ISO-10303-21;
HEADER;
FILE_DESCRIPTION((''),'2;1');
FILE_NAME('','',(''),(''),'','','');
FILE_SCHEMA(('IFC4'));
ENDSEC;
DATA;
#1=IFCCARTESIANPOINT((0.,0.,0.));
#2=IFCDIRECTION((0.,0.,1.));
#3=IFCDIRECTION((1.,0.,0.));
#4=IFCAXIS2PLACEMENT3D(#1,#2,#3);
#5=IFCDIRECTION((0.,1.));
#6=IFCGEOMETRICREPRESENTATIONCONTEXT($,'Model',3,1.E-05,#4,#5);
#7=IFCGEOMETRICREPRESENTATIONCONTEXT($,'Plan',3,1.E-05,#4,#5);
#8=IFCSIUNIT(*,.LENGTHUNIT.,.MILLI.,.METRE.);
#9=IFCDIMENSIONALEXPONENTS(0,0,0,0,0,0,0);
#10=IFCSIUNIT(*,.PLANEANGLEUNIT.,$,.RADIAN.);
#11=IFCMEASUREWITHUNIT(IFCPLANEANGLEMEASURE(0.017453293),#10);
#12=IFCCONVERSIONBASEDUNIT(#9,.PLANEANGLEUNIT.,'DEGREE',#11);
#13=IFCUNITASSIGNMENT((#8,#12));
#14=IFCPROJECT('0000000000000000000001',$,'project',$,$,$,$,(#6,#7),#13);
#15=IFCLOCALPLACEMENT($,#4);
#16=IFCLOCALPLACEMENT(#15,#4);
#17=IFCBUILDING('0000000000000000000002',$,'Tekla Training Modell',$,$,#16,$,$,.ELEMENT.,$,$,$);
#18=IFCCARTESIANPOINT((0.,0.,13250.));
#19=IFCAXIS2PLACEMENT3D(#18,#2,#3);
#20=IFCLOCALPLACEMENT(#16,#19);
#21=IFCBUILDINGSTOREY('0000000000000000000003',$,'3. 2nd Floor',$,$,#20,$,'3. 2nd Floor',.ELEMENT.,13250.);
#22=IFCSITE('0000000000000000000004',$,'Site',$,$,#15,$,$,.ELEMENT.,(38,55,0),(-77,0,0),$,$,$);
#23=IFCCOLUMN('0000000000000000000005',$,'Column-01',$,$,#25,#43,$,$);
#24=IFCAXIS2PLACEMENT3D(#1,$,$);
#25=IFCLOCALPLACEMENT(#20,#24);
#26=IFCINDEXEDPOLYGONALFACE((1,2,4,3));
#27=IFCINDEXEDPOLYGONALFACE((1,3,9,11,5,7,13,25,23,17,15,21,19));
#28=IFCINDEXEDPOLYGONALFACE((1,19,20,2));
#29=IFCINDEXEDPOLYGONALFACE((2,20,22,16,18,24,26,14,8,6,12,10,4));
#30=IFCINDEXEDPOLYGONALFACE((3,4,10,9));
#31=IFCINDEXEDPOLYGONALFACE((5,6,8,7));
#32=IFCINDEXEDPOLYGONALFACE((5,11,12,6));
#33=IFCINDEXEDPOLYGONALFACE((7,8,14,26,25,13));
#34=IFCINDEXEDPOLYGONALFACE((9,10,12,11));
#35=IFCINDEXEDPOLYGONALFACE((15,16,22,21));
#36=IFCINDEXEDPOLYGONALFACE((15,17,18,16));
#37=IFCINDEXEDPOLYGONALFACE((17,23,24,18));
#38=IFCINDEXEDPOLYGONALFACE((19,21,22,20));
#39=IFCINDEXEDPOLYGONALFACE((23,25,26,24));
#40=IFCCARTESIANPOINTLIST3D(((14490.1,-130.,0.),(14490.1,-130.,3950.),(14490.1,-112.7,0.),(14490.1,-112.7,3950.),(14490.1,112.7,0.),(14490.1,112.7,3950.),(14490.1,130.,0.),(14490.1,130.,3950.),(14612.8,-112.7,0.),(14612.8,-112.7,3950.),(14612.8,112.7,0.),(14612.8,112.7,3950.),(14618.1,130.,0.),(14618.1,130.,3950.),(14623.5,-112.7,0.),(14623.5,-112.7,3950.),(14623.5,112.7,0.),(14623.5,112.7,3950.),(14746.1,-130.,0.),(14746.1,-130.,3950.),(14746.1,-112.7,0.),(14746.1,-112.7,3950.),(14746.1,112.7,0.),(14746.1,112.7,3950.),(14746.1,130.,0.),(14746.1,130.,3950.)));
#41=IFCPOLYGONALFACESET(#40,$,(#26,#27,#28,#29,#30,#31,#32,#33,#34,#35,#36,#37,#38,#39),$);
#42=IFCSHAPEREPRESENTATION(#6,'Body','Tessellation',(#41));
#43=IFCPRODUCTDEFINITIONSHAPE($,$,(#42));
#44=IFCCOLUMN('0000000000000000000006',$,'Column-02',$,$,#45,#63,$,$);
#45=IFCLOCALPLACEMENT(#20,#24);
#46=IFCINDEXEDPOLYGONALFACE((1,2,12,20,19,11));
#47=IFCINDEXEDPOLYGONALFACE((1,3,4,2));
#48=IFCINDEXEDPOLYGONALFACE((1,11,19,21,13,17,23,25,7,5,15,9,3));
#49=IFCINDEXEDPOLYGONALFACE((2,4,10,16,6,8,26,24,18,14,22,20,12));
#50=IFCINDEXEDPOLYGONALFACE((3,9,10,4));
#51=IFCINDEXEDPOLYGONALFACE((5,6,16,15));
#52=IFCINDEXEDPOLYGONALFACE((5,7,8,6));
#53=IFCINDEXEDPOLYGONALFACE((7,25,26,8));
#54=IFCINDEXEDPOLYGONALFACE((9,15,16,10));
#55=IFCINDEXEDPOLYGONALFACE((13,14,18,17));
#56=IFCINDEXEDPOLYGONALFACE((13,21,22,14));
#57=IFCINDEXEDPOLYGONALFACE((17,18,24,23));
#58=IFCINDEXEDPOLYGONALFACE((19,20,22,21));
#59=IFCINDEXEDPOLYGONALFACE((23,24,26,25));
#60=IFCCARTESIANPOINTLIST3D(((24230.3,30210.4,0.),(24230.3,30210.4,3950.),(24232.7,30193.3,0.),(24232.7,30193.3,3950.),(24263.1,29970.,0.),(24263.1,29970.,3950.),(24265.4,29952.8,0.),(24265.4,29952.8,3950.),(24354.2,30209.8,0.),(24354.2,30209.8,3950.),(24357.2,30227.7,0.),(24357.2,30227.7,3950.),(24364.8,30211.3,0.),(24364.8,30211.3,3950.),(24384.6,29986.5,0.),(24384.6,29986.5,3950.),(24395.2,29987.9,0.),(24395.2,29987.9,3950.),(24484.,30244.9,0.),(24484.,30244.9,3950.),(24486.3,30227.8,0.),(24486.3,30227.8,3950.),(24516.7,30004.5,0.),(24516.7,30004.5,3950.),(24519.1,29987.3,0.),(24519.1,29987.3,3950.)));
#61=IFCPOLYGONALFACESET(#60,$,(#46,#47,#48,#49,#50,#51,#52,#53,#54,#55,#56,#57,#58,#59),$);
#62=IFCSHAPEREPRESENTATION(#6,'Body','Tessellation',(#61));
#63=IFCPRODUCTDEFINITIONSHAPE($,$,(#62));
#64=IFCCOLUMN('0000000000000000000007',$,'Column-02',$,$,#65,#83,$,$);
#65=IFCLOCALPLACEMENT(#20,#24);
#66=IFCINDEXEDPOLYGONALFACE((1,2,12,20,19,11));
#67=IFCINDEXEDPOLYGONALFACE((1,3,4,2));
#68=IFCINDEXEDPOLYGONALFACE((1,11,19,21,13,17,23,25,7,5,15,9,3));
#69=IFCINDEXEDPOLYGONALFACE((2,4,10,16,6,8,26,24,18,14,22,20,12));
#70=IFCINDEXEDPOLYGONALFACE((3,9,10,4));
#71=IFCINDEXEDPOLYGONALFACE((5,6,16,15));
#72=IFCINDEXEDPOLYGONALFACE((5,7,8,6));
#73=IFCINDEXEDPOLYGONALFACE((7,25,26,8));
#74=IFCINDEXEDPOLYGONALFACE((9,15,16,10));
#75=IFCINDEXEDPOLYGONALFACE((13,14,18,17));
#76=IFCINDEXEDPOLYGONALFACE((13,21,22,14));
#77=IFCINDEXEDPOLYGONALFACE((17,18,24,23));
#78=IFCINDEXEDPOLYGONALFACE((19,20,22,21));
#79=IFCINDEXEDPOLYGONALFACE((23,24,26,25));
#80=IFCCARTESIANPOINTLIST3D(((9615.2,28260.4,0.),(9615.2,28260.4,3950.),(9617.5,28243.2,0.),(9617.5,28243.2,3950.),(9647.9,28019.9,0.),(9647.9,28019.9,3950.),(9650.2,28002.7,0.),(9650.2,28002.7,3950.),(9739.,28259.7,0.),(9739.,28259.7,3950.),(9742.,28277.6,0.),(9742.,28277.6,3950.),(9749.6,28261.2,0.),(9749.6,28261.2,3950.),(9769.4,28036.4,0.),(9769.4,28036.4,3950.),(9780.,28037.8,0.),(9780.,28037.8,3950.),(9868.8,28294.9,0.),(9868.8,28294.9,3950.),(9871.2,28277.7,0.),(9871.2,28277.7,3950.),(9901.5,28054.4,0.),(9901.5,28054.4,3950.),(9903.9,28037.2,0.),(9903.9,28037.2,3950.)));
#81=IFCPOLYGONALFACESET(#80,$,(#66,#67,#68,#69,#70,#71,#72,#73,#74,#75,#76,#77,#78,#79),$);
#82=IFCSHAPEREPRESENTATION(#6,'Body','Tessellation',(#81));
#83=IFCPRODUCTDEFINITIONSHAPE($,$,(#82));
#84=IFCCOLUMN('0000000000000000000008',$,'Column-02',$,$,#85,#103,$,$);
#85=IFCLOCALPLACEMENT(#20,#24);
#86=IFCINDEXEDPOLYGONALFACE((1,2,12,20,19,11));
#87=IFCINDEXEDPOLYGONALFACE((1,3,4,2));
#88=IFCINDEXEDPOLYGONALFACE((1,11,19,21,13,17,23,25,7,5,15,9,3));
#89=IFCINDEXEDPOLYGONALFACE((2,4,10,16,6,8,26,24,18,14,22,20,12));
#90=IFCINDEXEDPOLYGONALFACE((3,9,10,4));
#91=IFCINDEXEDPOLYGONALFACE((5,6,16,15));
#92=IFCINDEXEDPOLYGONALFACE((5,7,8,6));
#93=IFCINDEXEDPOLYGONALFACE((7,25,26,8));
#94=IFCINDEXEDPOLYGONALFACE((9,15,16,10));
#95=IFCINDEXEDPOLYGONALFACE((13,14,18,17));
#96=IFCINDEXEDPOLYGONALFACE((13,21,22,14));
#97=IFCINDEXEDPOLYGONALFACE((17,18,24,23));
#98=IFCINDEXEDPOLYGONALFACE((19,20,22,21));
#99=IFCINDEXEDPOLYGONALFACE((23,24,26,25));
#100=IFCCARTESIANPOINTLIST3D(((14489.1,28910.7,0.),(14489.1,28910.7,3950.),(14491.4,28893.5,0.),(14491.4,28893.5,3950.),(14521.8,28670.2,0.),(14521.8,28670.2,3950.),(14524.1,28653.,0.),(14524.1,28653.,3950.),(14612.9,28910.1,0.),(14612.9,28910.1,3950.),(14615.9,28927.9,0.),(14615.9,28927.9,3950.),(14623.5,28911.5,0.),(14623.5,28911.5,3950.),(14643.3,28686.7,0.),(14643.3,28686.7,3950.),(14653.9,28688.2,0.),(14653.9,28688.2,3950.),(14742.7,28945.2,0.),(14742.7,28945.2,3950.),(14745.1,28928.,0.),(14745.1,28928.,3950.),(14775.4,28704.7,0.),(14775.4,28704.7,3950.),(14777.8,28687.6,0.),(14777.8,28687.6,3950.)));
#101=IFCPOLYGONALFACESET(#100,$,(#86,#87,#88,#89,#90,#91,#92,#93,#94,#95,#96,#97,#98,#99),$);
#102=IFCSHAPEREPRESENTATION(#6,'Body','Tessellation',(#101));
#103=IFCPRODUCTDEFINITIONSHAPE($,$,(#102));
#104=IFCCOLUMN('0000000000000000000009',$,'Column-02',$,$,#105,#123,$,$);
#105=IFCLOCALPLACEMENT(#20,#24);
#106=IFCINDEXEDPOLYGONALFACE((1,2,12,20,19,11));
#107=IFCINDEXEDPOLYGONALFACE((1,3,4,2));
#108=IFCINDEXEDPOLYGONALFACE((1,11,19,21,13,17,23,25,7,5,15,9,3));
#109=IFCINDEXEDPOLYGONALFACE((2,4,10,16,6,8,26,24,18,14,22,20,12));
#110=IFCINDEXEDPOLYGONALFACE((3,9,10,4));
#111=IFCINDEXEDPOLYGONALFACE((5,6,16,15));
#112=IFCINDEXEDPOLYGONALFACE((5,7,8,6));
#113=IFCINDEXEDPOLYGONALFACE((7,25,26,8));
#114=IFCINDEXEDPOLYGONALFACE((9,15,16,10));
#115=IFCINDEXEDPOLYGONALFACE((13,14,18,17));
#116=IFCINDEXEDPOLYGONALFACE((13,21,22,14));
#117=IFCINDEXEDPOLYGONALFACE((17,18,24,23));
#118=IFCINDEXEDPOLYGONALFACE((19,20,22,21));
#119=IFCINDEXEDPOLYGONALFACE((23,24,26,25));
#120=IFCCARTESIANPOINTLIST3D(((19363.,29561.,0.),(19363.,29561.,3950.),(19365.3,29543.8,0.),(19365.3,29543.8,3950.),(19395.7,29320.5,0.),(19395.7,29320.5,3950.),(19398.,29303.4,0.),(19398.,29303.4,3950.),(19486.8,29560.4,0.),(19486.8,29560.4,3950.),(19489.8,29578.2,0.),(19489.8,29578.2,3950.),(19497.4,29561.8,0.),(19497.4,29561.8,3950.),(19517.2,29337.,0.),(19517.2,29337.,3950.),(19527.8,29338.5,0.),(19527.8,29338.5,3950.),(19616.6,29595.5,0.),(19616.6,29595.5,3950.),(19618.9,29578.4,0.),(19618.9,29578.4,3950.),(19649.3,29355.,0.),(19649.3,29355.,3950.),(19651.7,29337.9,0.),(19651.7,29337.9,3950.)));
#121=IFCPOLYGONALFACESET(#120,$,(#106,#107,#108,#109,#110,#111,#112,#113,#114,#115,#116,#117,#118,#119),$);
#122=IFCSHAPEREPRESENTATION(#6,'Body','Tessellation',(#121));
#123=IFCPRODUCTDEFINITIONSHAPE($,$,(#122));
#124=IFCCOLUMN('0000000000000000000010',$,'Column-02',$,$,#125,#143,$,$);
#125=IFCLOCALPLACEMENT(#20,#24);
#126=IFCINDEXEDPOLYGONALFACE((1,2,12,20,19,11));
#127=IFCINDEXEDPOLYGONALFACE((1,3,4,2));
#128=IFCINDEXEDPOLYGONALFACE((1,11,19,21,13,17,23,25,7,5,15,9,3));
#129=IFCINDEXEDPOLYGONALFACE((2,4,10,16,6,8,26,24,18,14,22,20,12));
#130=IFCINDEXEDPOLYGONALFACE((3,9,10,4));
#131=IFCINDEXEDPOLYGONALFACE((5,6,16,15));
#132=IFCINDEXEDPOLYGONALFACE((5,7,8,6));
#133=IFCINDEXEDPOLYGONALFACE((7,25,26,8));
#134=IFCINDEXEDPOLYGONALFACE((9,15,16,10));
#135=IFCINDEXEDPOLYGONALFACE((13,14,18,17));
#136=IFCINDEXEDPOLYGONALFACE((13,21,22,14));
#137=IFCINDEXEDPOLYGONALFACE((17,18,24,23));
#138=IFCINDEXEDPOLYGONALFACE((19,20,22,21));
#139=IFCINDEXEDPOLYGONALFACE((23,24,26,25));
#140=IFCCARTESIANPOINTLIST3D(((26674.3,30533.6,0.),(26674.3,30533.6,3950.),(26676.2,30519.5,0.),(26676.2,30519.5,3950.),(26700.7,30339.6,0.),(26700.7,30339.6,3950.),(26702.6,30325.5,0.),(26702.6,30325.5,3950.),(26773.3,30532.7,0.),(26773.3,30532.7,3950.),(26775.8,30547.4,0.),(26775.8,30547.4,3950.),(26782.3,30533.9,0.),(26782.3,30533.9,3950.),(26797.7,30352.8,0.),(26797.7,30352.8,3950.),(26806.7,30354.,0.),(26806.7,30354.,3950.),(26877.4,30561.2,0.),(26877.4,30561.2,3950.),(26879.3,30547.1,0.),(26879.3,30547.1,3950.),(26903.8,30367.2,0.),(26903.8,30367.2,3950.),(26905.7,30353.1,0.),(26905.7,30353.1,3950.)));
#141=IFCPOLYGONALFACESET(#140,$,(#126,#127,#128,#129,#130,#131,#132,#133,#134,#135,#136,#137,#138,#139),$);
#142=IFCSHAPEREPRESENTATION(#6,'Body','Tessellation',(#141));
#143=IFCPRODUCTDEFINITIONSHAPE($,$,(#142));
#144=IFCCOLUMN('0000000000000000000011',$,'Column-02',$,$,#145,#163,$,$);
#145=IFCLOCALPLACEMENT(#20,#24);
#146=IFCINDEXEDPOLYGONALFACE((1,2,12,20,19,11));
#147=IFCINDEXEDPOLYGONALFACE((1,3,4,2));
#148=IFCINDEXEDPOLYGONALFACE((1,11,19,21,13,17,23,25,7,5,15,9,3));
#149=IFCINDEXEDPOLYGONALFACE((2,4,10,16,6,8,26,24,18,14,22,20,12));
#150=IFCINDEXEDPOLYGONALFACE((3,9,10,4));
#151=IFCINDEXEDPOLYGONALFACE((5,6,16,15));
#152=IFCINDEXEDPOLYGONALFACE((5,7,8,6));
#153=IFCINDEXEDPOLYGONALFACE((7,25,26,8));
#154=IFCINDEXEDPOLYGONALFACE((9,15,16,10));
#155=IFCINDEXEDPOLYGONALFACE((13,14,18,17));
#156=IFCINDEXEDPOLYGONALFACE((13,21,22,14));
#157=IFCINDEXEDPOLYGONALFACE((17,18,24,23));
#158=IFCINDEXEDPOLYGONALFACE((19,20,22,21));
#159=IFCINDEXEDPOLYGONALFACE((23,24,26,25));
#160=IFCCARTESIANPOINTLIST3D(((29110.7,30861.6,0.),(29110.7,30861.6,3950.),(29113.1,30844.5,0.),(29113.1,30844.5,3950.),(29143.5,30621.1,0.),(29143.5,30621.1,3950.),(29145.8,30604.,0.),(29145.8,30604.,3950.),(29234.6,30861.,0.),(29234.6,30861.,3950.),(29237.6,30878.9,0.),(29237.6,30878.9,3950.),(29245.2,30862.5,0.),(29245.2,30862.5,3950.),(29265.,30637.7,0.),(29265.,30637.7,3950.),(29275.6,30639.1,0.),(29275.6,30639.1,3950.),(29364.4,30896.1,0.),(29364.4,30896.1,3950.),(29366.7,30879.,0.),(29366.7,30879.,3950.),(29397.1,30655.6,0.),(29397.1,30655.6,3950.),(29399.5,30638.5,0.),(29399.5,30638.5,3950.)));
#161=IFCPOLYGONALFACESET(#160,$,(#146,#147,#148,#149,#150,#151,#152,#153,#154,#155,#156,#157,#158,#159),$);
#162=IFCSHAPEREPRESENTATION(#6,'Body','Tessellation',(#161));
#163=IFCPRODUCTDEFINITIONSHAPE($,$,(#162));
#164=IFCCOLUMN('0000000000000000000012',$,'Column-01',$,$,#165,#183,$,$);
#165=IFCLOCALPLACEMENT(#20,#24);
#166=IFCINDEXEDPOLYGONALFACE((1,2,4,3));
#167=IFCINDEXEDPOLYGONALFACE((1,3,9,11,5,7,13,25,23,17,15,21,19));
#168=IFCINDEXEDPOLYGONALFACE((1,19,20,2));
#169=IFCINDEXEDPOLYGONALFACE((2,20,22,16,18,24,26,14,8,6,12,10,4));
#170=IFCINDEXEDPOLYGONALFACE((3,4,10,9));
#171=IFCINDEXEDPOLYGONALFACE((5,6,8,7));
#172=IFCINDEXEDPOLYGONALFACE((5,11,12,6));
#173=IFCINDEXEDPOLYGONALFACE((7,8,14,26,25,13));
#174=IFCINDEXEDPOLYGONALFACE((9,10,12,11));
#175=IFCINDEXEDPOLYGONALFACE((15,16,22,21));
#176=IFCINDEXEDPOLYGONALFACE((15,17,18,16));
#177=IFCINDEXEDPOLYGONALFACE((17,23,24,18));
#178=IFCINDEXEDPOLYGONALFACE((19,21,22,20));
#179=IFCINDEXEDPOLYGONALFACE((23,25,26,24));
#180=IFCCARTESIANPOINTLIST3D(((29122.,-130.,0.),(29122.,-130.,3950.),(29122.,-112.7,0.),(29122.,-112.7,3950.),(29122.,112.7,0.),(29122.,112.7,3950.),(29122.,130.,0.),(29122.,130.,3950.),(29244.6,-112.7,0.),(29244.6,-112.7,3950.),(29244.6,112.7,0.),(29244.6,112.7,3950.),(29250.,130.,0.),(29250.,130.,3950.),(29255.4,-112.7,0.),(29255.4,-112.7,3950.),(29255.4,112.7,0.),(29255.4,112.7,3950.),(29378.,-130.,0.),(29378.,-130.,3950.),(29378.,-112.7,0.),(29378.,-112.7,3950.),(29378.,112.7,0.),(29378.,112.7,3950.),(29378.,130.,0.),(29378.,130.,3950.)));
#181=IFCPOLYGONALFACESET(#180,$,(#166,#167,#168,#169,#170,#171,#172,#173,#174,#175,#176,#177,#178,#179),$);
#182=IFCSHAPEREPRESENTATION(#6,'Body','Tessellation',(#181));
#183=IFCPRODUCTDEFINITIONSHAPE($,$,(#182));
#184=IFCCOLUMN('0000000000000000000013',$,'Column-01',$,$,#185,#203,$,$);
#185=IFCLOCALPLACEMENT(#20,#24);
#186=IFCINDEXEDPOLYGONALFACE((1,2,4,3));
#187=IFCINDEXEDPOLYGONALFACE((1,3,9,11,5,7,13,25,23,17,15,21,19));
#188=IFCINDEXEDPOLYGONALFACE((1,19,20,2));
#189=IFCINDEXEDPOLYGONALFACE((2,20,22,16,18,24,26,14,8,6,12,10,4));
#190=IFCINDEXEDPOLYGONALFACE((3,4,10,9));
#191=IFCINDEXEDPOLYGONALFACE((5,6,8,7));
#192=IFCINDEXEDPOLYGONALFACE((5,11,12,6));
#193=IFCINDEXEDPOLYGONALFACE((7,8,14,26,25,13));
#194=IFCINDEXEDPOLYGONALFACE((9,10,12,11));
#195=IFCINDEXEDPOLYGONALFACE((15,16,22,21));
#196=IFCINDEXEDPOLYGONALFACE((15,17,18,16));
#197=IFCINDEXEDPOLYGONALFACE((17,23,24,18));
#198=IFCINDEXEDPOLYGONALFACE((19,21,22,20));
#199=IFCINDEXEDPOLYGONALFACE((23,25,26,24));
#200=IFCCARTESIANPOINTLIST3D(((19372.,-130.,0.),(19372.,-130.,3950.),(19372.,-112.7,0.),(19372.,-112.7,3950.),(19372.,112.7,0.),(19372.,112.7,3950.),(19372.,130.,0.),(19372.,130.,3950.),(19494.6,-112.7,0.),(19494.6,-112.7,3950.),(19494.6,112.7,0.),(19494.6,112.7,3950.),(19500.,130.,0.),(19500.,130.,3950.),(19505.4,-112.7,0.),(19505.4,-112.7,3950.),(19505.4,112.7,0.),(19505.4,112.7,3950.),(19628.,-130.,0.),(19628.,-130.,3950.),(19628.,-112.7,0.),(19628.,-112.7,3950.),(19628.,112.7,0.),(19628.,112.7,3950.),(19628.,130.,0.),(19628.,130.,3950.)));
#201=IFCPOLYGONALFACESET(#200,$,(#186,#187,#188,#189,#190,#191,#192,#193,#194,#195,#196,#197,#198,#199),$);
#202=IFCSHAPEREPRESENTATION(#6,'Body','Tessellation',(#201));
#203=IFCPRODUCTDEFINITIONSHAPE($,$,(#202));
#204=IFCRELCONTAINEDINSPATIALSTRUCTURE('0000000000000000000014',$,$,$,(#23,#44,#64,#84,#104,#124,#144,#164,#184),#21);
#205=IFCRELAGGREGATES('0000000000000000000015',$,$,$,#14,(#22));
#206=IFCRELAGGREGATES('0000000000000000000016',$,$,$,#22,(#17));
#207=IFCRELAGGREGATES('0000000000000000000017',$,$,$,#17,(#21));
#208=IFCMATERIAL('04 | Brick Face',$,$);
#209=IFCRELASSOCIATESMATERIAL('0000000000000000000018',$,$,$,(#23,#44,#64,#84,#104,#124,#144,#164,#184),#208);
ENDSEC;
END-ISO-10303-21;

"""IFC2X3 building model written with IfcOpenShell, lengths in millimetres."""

from ifc_helpers import new_model, entity, si_unit, converted_unit, direction, frame, origin_with_axes, place, context, project, spatial, polyline, outline, extrude, material, element, save


model = new_model("IFC2X3")

# Units and contexts
model_context = context("Model", 3, precision=1e-05, world=origin_with_axes(), true_north=direction((0.0, 1.0)))
plan_context = context("Plan", 3, precision=1e-05, world=origin_with_axes(), true_north=direction((0.0, 1.0)))
ifc_project = project(units=[si_unit("LENGTHUNIT", "METRE", prefix="MILLI"), converted_unit("PLANEANGLEUNIT", "DEGREE", entity("IfcPlaneAngleMeasure", 0.017453293), si_unit("PLANEANGLEUNIT", "RADIAN"), dimensions=[0, 0, 0, 0, 0, 0, 0])], contexts=[model_context, plan_context])

# Site, building, storey
site_placement = place(None, origin_with_axes())
site = spatial("IfcSite", under=ifc_project, at=site_placement, Name="Site", CompositionType="ELEMENT", RefLatitude=(38, 55, 0), RefLongitude=(-77, 0, 0))
building_placement = place(site_placement, origin_with_axes())
building = spatial("IfcBuilding", under=site, at=building_placement, Name="Tekla Training Modell", CompositionType="ELEMENT")
storey_placement = place(building_placement, frame((0.0, 0.0, 13250.0), z_axis=(0.0, 0.0, 1.0), x_axis=(1.0, 0.0, 0.0)))
storey = spatial("IfcBuildingStorey", under=building, at=storey_placement, Name="3. 2nd Floor", LongName="3. 2nd Floor", CompositionType="ELEMENT", Elevation=13250.0)

# Columns
ifc_material_1 = material(Name="04 | Brick Face")
for number, where, z_axis, x_axis, name in (
    (1, (14618.1, 0.0, 0.0), (0.0, 0.0, 1.0), (1.0, 0.0, 0.0), "Column-01"),
    (2, (24374.7, 30098.9, 0.0), (0.0, 0.0, 1.0), (0.990872, 0.134803, 0.0), "Column-02"),
    (3, (9759.5, 28148.8, 0.0), (0.0, 0.0, 1.0), (0.990872, 0.134803, 0.0), "Column-02"),
    (4, (14633.4, 28799.1, 0.0), (0.0, 0.0, 1.0), (0.990872, 0.134803, 0.0), "Column-02"),
    (5, (19507.3, 29449.4, 0.0), (0.0, 0.0, 1.0), (0.990872, 0.134803, 0.0), "Column-02"),
):
    element("IfcColumn", number, at=place(storey_placement, frame(where, z_axis=z_axis, x_axis=x_axis)), inside=storey, material=ifc_material_1, Name=name, context=model_context, shape_type="SweptSolid", body=[
        extrude(outline(polyline([(0.0, 130.0), (-128.0, 130.0), (-128.0, 112.7), (-5.3, 112.7), (-5.3, -112.7), (-128.0, -112.7), (-128.0, -130.0), (128.0, -130.0), (128.0, -112.7), (5.3, -112.7), (5.3, 112.7), (128.0, 112.7), (128.0, 130.0), (0.0, 130.0)])), origin_with_axes(), (0.0, 0.0, 1.0), 3950.0),
    ])
column_placement = place(storey_placement, frame((26790.0, 30443.4, 0.0), z_axis=(0.0, 0.0, 1.0), x_axis=(0.990872, 0.134803, 0.0)))
element("IfcColumn", 6, at=column_placement, inside=storey, material=ifc_material_1, Name="Column-02", context=model_context, shape_type="SweptSolid", body=[
    extrude(outline(polyline([(0.0, 105.0), (-102.5, 105.0), (-102.5, 90.8), (-4.5, 90.8), (-4.5, -90.8), (-102.5, -90.8), (-102.5, -105.0), (102.5, -105.0), (102.5, -90.8), (4.5, -90.8), (4.5, 90.8), (102.5, 90.8), (102.5, 105.0), (0.0, 105.0)])), origin_with_axes(), (0.0, 0.0, 1.0), 3950.0),
])
for number, where, z_axis, x_axis, name in (
    (7, (29255.1, 30750.1, 0.0), (0.0, 0.0, 1.0), (0.990872, 0.134803, 0.0), "Column-02"),
    (8, (29250.0, 0.0, 0.0), (0.0, 0.0, 1.0), (1.0, 0.0, 0.0), "Column-01"),
    (9, (19500.0, 0.0, 0.0), (0.0, 0.0, 1.0), (1.0, 0.0, 0.0), "Column-01"),
):
    element("IfcColumn", number, at=place(storey_placement, frame(where, z_axis=z_axis, x_axis=x_axis)), inside=storey, material=ifc_material_1, Name=name, context=model_context, shape_type="SweptSolid", body=[
        extrude(outline(polyline([(0.0, 130.0), (-128.0, 130.0), (-128.0, 112.7), (-5.3, 112.7), (-5.3, -112.7), (-128.0, -112.7), (-128.0, -130.0), (128.0, -130.0), (128.0, -112.7), (5.3, -112.7), (5.3, 112.7), (128.0, 112.7), (128.0, 130.0), (0.0, 130.0)])), origin_with_axes(), (0.0, 0.0, 1.0), 3950.0),
    ])

save(model, "model.ifc")
